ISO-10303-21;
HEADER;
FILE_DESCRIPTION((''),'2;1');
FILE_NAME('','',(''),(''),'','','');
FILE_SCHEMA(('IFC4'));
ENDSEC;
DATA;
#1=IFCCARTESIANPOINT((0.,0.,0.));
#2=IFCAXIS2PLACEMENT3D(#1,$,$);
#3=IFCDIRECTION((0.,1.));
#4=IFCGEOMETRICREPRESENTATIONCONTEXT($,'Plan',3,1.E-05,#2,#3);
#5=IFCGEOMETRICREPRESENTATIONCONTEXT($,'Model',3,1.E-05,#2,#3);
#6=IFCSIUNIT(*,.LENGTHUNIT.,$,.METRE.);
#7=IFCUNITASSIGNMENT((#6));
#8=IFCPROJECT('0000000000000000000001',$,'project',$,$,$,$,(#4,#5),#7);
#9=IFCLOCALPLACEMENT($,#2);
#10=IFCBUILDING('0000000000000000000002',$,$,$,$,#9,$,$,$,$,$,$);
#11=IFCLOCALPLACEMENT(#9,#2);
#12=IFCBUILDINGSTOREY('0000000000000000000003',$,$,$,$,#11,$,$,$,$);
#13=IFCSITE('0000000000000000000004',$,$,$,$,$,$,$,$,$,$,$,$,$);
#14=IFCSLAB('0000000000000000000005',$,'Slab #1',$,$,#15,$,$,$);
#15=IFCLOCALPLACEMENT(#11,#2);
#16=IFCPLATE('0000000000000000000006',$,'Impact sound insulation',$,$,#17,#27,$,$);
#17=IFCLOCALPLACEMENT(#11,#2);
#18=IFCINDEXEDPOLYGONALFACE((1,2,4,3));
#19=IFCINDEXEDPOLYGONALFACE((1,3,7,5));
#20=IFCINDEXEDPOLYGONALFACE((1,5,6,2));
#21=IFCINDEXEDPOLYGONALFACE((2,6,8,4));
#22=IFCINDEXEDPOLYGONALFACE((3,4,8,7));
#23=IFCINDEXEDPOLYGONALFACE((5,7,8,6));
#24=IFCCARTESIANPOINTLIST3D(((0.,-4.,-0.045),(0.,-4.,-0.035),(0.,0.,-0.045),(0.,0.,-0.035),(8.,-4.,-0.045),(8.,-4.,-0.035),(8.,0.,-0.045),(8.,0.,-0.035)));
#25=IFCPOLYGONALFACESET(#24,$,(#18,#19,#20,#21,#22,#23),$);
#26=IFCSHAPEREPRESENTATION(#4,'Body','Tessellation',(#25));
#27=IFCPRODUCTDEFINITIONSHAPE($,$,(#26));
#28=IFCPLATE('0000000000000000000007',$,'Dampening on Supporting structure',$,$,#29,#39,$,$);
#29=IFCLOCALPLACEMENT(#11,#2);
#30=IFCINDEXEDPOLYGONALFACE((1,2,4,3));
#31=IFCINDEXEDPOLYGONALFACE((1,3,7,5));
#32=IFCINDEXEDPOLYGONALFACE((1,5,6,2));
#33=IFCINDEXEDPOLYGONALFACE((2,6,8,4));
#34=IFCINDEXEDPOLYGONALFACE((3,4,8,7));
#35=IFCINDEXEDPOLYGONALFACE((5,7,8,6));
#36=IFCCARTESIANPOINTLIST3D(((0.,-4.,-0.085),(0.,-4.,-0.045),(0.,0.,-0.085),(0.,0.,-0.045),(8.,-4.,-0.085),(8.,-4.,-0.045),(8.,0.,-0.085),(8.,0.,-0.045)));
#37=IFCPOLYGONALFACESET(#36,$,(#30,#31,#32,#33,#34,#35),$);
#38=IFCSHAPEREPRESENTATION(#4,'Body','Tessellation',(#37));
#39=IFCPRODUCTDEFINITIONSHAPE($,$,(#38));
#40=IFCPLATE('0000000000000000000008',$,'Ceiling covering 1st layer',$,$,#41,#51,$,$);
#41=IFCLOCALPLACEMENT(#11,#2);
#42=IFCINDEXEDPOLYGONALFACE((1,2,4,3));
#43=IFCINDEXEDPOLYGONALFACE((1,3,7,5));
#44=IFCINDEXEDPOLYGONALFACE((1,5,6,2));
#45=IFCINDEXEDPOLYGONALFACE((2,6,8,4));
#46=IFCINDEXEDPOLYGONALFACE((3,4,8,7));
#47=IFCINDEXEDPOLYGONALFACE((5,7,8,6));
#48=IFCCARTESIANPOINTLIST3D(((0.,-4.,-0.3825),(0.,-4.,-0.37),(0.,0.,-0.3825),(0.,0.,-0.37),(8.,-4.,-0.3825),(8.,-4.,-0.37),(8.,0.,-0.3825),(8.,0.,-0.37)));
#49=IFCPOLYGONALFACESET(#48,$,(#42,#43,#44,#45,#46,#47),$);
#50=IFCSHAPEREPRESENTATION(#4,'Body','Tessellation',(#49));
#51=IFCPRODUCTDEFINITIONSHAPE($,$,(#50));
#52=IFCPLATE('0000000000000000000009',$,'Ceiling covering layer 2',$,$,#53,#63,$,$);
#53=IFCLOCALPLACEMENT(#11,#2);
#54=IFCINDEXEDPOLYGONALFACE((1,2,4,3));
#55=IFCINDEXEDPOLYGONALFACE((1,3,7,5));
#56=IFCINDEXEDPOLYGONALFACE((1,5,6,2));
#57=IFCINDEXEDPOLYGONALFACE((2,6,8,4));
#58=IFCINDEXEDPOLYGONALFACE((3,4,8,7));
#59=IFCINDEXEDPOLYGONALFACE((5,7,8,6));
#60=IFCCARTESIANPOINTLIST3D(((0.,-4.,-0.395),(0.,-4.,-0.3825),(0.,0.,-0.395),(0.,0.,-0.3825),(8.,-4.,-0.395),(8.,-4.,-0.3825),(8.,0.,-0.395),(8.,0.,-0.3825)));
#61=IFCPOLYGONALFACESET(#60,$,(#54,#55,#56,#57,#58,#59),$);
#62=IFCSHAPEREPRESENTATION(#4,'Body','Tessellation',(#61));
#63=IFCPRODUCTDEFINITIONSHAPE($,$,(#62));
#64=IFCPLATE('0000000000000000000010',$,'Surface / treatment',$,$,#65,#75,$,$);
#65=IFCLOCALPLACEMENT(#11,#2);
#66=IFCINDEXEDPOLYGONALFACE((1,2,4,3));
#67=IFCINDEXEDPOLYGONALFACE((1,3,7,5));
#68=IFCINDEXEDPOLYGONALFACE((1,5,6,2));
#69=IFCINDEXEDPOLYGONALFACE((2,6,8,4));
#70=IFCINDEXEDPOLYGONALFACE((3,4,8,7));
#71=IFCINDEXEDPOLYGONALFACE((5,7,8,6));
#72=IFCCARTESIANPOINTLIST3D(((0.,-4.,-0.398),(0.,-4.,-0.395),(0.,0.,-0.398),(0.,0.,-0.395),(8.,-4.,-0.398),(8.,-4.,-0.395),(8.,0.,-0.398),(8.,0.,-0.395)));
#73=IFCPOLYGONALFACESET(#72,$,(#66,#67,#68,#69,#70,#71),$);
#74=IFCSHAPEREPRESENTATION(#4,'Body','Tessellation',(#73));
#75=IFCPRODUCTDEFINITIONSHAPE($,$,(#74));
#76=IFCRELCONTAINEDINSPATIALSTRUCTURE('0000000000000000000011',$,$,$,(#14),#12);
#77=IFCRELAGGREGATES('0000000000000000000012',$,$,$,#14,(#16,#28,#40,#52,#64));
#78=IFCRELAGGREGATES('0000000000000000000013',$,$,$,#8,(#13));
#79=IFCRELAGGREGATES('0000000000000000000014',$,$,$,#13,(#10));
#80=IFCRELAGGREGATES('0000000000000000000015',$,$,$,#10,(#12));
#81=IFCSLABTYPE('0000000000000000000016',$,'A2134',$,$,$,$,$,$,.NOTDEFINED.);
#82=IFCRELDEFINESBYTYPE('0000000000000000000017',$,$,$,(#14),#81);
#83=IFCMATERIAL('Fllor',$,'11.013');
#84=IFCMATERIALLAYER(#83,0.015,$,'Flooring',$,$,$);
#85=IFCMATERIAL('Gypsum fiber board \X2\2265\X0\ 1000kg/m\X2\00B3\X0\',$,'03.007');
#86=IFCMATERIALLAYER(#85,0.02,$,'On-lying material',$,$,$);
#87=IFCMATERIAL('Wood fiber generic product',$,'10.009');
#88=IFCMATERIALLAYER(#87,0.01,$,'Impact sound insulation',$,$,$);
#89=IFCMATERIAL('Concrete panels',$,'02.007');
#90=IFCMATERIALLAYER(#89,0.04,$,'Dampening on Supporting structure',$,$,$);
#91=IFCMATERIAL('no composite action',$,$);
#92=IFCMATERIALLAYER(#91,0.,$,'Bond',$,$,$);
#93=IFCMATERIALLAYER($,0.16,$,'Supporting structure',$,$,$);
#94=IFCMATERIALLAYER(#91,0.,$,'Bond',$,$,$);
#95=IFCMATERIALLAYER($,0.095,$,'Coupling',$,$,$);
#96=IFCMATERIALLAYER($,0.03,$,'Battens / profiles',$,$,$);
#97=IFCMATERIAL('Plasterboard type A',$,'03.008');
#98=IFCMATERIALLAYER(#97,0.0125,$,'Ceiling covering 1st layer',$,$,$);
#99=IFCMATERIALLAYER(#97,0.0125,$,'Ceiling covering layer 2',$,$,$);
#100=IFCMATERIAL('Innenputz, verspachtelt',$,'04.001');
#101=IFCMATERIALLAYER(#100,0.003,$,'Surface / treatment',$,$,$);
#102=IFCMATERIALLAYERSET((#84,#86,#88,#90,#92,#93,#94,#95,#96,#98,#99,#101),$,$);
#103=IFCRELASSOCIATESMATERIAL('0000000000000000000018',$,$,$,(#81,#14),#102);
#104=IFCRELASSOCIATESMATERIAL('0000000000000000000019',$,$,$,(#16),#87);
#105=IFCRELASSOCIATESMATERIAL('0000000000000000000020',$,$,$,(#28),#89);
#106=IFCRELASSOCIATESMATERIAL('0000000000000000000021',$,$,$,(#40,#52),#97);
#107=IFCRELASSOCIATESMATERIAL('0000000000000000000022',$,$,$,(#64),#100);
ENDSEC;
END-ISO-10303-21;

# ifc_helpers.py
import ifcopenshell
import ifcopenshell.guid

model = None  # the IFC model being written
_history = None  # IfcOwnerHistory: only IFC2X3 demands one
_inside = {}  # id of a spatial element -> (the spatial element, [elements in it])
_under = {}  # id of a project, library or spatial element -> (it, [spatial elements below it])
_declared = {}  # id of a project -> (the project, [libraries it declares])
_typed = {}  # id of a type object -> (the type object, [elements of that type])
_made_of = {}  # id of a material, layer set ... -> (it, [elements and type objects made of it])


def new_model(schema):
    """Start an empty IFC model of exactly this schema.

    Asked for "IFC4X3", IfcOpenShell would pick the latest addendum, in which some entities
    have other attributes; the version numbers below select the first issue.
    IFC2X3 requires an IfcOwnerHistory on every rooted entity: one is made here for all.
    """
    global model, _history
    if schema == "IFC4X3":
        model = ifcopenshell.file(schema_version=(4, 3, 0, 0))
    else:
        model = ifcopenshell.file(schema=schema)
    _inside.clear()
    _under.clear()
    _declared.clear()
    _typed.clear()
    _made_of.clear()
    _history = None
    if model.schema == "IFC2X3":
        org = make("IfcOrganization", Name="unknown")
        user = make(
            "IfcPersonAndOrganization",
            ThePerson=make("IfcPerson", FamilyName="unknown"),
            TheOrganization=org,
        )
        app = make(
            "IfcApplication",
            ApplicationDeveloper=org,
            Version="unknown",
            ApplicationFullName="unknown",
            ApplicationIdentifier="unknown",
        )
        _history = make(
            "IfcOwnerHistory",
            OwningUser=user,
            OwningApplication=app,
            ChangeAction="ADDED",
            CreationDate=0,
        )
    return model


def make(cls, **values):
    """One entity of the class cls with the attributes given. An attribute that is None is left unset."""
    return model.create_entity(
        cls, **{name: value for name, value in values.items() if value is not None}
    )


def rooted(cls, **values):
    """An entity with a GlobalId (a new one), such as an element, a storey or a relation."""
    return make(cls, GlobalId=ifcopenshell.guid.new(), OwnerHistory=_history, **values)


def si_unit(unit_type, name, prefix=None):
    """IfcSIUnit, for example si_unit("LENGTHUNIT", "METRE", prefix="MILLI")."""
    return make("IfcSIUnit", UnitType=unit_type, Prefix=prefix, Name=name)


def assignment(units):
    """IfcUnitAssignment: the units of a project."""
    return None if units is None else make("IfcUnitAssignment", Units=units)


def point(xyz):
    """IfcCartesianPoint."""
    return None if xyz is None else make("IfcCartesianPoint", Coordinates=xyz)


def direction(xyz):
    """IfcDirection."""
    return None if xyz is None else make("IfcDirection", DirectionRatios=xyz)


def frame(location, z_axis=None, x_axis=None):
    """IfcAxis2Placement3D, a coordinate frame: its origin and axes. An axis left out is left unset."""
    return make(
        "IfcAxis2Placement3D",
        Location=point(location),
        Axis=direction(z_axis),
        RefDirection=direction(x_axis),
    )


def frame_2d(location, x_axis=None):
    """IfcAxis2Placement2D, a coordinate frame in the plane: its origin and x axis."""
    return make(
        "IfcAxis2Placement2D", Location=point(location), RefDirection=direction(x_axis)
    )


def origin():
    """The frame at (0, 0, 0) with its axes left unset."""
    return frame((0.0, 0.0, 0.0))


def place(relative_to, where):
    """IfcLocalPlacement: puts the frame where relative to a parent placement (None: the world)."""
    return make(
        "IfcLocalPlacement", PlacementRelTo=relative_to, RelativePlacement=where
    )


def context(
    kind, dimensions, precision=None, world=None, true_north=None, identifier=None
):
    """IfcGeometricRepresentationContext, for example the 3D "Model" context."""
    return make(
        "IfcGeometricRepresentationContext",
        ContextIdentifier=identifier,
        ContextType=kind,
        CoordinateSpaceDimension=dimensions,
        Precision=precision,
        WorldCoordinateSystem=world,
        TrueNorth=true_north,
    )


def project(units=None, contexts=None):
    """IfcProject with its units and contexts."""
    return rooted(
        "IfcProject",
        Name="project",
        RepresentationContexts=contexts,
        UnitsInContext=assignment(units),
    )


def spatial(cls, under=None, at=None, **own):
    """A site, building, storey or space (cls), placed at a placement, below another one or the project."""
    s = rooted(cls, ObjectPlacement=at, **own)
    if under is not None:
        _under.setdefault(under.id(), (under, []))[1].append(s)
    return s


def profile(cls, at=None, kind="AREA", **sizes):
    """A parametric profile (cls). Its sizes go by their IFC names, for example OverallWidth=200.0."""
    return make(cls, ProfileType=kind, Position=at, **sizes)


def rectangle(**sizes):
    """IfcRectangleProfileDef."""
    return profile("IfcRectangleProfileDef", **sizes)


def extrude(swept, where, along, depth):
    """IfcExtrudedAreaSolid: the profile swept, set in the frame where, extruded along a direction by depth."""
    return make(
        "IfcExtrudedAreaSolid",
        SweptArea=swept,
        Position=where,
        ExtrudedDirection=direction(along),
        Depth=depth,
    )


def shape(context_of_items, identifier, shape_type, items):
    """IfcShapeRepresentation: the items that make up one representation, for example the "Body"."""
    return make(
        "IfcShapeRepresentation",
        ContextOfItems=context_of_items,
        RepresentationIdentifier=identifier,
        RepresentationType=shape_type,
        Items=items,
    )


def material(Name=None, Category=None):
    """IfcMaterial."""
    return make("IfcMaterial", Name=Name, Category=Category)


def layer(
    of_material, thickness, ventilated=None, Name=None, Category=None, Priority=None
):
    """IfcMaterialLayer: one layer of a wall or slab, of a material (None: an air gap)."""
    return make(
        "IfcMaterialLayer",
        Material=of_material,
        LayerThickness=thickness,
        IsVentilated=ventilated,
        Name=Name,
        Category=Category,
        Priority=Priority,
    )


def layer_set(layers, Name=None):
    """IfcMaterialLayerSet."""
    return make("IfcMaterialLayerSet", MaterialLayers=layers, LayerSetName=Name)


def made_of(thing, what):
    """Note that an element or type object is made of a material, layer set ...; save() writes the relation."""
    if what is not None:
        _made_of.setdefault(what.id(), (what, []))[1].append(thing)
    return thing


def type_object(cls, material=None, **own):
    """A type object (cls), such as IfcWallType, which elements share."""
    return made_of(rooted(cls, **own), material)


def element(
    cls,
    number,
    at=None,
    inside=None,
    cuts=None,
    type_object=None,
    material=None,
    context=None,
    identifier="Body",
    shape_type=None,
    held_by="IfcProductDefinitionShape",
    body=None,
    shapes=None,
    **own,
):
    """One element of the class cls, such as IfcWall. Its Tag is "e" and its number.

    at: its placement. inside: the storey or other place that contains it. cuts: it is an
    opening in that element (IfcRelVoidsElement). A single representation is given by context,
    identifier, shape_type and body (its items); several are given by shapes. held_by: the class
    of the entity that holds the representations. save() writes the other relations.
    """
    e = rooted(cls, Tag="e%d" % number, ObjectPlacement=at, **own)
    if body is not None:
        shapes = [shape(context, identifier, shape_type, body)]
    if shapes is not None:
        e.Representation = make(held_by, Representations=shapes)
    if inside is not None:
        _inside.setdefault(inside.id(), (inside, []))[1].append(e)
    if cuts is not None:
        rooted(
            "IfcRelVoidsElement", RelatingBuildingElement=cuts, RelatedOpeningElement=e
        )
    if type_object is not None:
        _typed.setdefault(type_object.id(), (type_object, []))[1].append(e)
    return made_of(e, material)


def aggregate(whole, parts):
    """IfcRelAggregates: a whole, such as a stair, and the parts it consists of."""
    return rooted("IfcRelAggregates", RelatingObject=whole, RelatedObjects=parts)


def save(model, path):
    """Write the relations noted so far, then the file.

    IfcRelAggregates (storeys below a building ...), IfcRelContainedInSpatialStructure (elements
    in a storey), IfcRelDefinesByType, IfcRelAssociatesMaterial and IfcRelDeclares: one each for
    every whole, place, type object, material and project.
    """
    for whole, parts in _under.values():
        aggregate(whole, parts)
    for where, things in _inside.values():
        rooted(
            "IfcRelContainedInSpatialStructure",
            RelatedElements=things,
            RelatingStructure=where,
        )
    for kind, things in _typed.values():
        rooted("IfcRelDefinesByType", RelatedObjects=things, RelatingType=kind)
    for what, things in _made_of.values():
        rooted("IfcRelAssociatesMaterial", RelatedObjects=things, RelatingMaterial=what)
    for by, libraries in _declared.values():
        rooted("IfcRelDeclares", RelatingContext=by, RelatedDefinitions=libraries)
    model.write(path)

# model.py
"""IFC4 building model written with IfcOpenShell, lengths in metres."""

from ifc_helpers import new_model, si_unit, direction, frame, frame_2d, origin, place, context, project, spatial, rectangle, extrude, material, layer, layer_set, type_object, element, aggregate, save


model = new_model("IFC4")

# Units and contexts
plan_context = context("Plan", 3, precision=1e-05, world=origin(), true_north=direction((0.0, 1.0)))
model_context = context("Model", 3, precision=1e-05, world=origin(), true_north=direction((0.0, 1.0)))
ifc_project = project(units=[si_unit("LENGTHUNIT", "METRE")], contexts=[plan_context, model_context])

# Site, building, storey
site = spatial("IfcSite", under=ifc_project)
building_placement = place(None, origin())
building = spatial("IfcBuilding", under=site, at=building_placement)
storey_placement = place(building_placement, origin())
storey = spatial("IfcBuildingStorey", under=building, at=storey_placement)

# Slab, plates
ifc_material_1 = material(Name="Fllor", Category="11.013")
ifc_layer_1 = layer(ifc_material_1, 0.015, Name="Flooring")
ifc_material_2 = material(Name="Gypsum fiber board ≥ 1000kg/m³", Category="03.007")
ifc_layer_2 = layer(ifc_material_2, 0.02, Name="On-lying material")
ifc_material_3 = material(Name="Wood fiber generic product", Category="10.009")
ifc_layer_3 = layer(ifc_material_3, 0.01, Name="Impact sound insulation")
ifc_material_4 = material(Name="Concrete panels", Category="02.007")
ifc_layer_4 = layer(ifc_material_4, 0.04, Name="Dampening on Supporting structure")
ifc_material_5 = material(Name="no composite action")
ifc_layer_5 = layer(ifc_material_5, 0.0, Name="Bond")
ifc_layer_6 = layer(None, 0.16, Name="Supporting structure")
ifc_layer_7 = layer(ifc_material_5, 0.0, Name="Bond")
ifc_layer_8 = layer(None, 0.095, Name="Coupling")
ifc_layer_9 = layer(None, 0.03, Name="Battens / profiles")
ifc_material_6 = material(Name="Plasterboard type A", Category="03.008")
ifc_layer_10 = layer(ifc_material_6, 0.0125, Name="Ceiling covering 1st layer")
ifc_layer_11 = layer(ifc_material_6, 0.0125, Name="Ceiling covering layer 2")
ifc_material_7 = material(Name="Innenputz, verspachtelt", Category="04.001")
ifc_layer_12 = layer(ifc_material_7, 0.003, Name="Surface / treatment")
ifc_layer_set = layer_set([ifc_layer_1, ifc_layer_2, ifc_layer_3, ifc_layer_4, ifc_layer_5, ifc_layer_6, ifc_layer_7, ifc_layer_8, ifc_layer_9, ifc_layer_10, ifc_layer_11, ifc_layer_12])
slab_type = type_object("IfcSlabType", Name="A2134", PredefinedType="NOTDEFINED", material=ifc_layer_set)
slab_placement = place(None, frame((0.0, 0.0, 0.0), z_axis=(0.0, 0.0, -1.0), x_axis=(1.0, 0.0, 0.0)))
slab = element("IfcSlab", 1, at=slab_placement, inside=storey, type_object=slab_type, material=ifc_layer_set, Name="Slab #1")
plate_1_placement = place(slab_placement, origin())
plate_1 = element("IfcPlate", 2, at=plate_1_placement, material=ifc_material_3, Name="Impact sound insulation", context=plan_context, shape_type="SweptSolid", body=[
    extrude(rectangle(XDim=8.0, YDim=4.0, at=frame_2d((4.0, 2.0), x_axis=(1.0, 0.0))), frame((0.0, 0.0, 0.035), z_axis=(0.0, 0.0, 1.0), x_axis=(1.0, 0.0, 0.0)), (0.0, 0.0, 1.0), 0.01),
])
plate_2_placement = place(slab_placement, origin())
plate_2 = element("IfcPlate", 3, at=plate_2_placement, material=ifc_material_4, Name="Dampening on Supporting structure", context=plan_context, shape_type="SweptSolid", body=[
    extrude(rectangle(XDim=8.0, YDim=4.0, at=frame_2d((4.0, 2.0), x_axis=(1.0, 0.0))), frame((0.0, 0.0, 0.045), z_axis=(0.0, 0.0, 1.0), x_axis=(1.0, 0.0, 0.0)), (0.0, 0.0, 1.0), 0.04),
])
plate_3_placement = place(slab_placement, origin())
plate_3 = element("IfcPlate", 4, at=plate_3_placement, material=ifc_material_6, Name="Ceiling covering 1st layer", context=plan_context, shape_type="SweptSolid", body=[
    extrude(rectangle(XDim=8.0, YDim=4.0, at=frame_2d((4.0, 2.0), x_axis=(1.0, 0.0))), frame((0.0, 0.0, 0.37), z_axis=(0.0, 0.0, 1.0), x_axis=(1.0, 0.0, 0.0)), (0.0, 0.0, 1.0), 0.0125),
])
plate_4_placement = place(slab_placement, origin())
plate_4 = element("IfcPlate", 5, at=plate_4_placement, material=ifc_material_6, Name="Ceiling covering layer 2", context=plan_context, shape_type="SweptSolid", body=[
    extrude(rectangle(XDim=8.0, YDim=4.0, at=frame_2d((4.0, 2.0), x_axis=(1.0, 0.0))), frame((0.0, 0.0, 0.3825), z_axis=(0.0, 0.0, 1.0), x_axis=(1.0, 0.0, 0.0)), (0.0, 0.0, 1.0), 0.0125),
])
plate_5_placement = place(slab_placement, origin())
plate_5 = element("IfcPlate", 6, at=plate_5_placement, material=ifc_material_7, Name="Surface / treatment", context=plan_context, shape_type="SweptSolid", body=[
    extrude(rectangle(XDim=8.0, YDim=4.0, at=frame_2d((4.0, 2.0), x_axis=(1.0, 0.0))), frame((0.0, 0.0, 0.395), z_axis=(0.0, 0.0, 1.0), x_axis=(1.0, 0.0, 0.0)), (0.0, 0.0, 1.0), 0.003),
])
aggregate(slab, [plate_1, plate_2, plate_3, plate_4, plate_5])

save(model, "model.ifc")
